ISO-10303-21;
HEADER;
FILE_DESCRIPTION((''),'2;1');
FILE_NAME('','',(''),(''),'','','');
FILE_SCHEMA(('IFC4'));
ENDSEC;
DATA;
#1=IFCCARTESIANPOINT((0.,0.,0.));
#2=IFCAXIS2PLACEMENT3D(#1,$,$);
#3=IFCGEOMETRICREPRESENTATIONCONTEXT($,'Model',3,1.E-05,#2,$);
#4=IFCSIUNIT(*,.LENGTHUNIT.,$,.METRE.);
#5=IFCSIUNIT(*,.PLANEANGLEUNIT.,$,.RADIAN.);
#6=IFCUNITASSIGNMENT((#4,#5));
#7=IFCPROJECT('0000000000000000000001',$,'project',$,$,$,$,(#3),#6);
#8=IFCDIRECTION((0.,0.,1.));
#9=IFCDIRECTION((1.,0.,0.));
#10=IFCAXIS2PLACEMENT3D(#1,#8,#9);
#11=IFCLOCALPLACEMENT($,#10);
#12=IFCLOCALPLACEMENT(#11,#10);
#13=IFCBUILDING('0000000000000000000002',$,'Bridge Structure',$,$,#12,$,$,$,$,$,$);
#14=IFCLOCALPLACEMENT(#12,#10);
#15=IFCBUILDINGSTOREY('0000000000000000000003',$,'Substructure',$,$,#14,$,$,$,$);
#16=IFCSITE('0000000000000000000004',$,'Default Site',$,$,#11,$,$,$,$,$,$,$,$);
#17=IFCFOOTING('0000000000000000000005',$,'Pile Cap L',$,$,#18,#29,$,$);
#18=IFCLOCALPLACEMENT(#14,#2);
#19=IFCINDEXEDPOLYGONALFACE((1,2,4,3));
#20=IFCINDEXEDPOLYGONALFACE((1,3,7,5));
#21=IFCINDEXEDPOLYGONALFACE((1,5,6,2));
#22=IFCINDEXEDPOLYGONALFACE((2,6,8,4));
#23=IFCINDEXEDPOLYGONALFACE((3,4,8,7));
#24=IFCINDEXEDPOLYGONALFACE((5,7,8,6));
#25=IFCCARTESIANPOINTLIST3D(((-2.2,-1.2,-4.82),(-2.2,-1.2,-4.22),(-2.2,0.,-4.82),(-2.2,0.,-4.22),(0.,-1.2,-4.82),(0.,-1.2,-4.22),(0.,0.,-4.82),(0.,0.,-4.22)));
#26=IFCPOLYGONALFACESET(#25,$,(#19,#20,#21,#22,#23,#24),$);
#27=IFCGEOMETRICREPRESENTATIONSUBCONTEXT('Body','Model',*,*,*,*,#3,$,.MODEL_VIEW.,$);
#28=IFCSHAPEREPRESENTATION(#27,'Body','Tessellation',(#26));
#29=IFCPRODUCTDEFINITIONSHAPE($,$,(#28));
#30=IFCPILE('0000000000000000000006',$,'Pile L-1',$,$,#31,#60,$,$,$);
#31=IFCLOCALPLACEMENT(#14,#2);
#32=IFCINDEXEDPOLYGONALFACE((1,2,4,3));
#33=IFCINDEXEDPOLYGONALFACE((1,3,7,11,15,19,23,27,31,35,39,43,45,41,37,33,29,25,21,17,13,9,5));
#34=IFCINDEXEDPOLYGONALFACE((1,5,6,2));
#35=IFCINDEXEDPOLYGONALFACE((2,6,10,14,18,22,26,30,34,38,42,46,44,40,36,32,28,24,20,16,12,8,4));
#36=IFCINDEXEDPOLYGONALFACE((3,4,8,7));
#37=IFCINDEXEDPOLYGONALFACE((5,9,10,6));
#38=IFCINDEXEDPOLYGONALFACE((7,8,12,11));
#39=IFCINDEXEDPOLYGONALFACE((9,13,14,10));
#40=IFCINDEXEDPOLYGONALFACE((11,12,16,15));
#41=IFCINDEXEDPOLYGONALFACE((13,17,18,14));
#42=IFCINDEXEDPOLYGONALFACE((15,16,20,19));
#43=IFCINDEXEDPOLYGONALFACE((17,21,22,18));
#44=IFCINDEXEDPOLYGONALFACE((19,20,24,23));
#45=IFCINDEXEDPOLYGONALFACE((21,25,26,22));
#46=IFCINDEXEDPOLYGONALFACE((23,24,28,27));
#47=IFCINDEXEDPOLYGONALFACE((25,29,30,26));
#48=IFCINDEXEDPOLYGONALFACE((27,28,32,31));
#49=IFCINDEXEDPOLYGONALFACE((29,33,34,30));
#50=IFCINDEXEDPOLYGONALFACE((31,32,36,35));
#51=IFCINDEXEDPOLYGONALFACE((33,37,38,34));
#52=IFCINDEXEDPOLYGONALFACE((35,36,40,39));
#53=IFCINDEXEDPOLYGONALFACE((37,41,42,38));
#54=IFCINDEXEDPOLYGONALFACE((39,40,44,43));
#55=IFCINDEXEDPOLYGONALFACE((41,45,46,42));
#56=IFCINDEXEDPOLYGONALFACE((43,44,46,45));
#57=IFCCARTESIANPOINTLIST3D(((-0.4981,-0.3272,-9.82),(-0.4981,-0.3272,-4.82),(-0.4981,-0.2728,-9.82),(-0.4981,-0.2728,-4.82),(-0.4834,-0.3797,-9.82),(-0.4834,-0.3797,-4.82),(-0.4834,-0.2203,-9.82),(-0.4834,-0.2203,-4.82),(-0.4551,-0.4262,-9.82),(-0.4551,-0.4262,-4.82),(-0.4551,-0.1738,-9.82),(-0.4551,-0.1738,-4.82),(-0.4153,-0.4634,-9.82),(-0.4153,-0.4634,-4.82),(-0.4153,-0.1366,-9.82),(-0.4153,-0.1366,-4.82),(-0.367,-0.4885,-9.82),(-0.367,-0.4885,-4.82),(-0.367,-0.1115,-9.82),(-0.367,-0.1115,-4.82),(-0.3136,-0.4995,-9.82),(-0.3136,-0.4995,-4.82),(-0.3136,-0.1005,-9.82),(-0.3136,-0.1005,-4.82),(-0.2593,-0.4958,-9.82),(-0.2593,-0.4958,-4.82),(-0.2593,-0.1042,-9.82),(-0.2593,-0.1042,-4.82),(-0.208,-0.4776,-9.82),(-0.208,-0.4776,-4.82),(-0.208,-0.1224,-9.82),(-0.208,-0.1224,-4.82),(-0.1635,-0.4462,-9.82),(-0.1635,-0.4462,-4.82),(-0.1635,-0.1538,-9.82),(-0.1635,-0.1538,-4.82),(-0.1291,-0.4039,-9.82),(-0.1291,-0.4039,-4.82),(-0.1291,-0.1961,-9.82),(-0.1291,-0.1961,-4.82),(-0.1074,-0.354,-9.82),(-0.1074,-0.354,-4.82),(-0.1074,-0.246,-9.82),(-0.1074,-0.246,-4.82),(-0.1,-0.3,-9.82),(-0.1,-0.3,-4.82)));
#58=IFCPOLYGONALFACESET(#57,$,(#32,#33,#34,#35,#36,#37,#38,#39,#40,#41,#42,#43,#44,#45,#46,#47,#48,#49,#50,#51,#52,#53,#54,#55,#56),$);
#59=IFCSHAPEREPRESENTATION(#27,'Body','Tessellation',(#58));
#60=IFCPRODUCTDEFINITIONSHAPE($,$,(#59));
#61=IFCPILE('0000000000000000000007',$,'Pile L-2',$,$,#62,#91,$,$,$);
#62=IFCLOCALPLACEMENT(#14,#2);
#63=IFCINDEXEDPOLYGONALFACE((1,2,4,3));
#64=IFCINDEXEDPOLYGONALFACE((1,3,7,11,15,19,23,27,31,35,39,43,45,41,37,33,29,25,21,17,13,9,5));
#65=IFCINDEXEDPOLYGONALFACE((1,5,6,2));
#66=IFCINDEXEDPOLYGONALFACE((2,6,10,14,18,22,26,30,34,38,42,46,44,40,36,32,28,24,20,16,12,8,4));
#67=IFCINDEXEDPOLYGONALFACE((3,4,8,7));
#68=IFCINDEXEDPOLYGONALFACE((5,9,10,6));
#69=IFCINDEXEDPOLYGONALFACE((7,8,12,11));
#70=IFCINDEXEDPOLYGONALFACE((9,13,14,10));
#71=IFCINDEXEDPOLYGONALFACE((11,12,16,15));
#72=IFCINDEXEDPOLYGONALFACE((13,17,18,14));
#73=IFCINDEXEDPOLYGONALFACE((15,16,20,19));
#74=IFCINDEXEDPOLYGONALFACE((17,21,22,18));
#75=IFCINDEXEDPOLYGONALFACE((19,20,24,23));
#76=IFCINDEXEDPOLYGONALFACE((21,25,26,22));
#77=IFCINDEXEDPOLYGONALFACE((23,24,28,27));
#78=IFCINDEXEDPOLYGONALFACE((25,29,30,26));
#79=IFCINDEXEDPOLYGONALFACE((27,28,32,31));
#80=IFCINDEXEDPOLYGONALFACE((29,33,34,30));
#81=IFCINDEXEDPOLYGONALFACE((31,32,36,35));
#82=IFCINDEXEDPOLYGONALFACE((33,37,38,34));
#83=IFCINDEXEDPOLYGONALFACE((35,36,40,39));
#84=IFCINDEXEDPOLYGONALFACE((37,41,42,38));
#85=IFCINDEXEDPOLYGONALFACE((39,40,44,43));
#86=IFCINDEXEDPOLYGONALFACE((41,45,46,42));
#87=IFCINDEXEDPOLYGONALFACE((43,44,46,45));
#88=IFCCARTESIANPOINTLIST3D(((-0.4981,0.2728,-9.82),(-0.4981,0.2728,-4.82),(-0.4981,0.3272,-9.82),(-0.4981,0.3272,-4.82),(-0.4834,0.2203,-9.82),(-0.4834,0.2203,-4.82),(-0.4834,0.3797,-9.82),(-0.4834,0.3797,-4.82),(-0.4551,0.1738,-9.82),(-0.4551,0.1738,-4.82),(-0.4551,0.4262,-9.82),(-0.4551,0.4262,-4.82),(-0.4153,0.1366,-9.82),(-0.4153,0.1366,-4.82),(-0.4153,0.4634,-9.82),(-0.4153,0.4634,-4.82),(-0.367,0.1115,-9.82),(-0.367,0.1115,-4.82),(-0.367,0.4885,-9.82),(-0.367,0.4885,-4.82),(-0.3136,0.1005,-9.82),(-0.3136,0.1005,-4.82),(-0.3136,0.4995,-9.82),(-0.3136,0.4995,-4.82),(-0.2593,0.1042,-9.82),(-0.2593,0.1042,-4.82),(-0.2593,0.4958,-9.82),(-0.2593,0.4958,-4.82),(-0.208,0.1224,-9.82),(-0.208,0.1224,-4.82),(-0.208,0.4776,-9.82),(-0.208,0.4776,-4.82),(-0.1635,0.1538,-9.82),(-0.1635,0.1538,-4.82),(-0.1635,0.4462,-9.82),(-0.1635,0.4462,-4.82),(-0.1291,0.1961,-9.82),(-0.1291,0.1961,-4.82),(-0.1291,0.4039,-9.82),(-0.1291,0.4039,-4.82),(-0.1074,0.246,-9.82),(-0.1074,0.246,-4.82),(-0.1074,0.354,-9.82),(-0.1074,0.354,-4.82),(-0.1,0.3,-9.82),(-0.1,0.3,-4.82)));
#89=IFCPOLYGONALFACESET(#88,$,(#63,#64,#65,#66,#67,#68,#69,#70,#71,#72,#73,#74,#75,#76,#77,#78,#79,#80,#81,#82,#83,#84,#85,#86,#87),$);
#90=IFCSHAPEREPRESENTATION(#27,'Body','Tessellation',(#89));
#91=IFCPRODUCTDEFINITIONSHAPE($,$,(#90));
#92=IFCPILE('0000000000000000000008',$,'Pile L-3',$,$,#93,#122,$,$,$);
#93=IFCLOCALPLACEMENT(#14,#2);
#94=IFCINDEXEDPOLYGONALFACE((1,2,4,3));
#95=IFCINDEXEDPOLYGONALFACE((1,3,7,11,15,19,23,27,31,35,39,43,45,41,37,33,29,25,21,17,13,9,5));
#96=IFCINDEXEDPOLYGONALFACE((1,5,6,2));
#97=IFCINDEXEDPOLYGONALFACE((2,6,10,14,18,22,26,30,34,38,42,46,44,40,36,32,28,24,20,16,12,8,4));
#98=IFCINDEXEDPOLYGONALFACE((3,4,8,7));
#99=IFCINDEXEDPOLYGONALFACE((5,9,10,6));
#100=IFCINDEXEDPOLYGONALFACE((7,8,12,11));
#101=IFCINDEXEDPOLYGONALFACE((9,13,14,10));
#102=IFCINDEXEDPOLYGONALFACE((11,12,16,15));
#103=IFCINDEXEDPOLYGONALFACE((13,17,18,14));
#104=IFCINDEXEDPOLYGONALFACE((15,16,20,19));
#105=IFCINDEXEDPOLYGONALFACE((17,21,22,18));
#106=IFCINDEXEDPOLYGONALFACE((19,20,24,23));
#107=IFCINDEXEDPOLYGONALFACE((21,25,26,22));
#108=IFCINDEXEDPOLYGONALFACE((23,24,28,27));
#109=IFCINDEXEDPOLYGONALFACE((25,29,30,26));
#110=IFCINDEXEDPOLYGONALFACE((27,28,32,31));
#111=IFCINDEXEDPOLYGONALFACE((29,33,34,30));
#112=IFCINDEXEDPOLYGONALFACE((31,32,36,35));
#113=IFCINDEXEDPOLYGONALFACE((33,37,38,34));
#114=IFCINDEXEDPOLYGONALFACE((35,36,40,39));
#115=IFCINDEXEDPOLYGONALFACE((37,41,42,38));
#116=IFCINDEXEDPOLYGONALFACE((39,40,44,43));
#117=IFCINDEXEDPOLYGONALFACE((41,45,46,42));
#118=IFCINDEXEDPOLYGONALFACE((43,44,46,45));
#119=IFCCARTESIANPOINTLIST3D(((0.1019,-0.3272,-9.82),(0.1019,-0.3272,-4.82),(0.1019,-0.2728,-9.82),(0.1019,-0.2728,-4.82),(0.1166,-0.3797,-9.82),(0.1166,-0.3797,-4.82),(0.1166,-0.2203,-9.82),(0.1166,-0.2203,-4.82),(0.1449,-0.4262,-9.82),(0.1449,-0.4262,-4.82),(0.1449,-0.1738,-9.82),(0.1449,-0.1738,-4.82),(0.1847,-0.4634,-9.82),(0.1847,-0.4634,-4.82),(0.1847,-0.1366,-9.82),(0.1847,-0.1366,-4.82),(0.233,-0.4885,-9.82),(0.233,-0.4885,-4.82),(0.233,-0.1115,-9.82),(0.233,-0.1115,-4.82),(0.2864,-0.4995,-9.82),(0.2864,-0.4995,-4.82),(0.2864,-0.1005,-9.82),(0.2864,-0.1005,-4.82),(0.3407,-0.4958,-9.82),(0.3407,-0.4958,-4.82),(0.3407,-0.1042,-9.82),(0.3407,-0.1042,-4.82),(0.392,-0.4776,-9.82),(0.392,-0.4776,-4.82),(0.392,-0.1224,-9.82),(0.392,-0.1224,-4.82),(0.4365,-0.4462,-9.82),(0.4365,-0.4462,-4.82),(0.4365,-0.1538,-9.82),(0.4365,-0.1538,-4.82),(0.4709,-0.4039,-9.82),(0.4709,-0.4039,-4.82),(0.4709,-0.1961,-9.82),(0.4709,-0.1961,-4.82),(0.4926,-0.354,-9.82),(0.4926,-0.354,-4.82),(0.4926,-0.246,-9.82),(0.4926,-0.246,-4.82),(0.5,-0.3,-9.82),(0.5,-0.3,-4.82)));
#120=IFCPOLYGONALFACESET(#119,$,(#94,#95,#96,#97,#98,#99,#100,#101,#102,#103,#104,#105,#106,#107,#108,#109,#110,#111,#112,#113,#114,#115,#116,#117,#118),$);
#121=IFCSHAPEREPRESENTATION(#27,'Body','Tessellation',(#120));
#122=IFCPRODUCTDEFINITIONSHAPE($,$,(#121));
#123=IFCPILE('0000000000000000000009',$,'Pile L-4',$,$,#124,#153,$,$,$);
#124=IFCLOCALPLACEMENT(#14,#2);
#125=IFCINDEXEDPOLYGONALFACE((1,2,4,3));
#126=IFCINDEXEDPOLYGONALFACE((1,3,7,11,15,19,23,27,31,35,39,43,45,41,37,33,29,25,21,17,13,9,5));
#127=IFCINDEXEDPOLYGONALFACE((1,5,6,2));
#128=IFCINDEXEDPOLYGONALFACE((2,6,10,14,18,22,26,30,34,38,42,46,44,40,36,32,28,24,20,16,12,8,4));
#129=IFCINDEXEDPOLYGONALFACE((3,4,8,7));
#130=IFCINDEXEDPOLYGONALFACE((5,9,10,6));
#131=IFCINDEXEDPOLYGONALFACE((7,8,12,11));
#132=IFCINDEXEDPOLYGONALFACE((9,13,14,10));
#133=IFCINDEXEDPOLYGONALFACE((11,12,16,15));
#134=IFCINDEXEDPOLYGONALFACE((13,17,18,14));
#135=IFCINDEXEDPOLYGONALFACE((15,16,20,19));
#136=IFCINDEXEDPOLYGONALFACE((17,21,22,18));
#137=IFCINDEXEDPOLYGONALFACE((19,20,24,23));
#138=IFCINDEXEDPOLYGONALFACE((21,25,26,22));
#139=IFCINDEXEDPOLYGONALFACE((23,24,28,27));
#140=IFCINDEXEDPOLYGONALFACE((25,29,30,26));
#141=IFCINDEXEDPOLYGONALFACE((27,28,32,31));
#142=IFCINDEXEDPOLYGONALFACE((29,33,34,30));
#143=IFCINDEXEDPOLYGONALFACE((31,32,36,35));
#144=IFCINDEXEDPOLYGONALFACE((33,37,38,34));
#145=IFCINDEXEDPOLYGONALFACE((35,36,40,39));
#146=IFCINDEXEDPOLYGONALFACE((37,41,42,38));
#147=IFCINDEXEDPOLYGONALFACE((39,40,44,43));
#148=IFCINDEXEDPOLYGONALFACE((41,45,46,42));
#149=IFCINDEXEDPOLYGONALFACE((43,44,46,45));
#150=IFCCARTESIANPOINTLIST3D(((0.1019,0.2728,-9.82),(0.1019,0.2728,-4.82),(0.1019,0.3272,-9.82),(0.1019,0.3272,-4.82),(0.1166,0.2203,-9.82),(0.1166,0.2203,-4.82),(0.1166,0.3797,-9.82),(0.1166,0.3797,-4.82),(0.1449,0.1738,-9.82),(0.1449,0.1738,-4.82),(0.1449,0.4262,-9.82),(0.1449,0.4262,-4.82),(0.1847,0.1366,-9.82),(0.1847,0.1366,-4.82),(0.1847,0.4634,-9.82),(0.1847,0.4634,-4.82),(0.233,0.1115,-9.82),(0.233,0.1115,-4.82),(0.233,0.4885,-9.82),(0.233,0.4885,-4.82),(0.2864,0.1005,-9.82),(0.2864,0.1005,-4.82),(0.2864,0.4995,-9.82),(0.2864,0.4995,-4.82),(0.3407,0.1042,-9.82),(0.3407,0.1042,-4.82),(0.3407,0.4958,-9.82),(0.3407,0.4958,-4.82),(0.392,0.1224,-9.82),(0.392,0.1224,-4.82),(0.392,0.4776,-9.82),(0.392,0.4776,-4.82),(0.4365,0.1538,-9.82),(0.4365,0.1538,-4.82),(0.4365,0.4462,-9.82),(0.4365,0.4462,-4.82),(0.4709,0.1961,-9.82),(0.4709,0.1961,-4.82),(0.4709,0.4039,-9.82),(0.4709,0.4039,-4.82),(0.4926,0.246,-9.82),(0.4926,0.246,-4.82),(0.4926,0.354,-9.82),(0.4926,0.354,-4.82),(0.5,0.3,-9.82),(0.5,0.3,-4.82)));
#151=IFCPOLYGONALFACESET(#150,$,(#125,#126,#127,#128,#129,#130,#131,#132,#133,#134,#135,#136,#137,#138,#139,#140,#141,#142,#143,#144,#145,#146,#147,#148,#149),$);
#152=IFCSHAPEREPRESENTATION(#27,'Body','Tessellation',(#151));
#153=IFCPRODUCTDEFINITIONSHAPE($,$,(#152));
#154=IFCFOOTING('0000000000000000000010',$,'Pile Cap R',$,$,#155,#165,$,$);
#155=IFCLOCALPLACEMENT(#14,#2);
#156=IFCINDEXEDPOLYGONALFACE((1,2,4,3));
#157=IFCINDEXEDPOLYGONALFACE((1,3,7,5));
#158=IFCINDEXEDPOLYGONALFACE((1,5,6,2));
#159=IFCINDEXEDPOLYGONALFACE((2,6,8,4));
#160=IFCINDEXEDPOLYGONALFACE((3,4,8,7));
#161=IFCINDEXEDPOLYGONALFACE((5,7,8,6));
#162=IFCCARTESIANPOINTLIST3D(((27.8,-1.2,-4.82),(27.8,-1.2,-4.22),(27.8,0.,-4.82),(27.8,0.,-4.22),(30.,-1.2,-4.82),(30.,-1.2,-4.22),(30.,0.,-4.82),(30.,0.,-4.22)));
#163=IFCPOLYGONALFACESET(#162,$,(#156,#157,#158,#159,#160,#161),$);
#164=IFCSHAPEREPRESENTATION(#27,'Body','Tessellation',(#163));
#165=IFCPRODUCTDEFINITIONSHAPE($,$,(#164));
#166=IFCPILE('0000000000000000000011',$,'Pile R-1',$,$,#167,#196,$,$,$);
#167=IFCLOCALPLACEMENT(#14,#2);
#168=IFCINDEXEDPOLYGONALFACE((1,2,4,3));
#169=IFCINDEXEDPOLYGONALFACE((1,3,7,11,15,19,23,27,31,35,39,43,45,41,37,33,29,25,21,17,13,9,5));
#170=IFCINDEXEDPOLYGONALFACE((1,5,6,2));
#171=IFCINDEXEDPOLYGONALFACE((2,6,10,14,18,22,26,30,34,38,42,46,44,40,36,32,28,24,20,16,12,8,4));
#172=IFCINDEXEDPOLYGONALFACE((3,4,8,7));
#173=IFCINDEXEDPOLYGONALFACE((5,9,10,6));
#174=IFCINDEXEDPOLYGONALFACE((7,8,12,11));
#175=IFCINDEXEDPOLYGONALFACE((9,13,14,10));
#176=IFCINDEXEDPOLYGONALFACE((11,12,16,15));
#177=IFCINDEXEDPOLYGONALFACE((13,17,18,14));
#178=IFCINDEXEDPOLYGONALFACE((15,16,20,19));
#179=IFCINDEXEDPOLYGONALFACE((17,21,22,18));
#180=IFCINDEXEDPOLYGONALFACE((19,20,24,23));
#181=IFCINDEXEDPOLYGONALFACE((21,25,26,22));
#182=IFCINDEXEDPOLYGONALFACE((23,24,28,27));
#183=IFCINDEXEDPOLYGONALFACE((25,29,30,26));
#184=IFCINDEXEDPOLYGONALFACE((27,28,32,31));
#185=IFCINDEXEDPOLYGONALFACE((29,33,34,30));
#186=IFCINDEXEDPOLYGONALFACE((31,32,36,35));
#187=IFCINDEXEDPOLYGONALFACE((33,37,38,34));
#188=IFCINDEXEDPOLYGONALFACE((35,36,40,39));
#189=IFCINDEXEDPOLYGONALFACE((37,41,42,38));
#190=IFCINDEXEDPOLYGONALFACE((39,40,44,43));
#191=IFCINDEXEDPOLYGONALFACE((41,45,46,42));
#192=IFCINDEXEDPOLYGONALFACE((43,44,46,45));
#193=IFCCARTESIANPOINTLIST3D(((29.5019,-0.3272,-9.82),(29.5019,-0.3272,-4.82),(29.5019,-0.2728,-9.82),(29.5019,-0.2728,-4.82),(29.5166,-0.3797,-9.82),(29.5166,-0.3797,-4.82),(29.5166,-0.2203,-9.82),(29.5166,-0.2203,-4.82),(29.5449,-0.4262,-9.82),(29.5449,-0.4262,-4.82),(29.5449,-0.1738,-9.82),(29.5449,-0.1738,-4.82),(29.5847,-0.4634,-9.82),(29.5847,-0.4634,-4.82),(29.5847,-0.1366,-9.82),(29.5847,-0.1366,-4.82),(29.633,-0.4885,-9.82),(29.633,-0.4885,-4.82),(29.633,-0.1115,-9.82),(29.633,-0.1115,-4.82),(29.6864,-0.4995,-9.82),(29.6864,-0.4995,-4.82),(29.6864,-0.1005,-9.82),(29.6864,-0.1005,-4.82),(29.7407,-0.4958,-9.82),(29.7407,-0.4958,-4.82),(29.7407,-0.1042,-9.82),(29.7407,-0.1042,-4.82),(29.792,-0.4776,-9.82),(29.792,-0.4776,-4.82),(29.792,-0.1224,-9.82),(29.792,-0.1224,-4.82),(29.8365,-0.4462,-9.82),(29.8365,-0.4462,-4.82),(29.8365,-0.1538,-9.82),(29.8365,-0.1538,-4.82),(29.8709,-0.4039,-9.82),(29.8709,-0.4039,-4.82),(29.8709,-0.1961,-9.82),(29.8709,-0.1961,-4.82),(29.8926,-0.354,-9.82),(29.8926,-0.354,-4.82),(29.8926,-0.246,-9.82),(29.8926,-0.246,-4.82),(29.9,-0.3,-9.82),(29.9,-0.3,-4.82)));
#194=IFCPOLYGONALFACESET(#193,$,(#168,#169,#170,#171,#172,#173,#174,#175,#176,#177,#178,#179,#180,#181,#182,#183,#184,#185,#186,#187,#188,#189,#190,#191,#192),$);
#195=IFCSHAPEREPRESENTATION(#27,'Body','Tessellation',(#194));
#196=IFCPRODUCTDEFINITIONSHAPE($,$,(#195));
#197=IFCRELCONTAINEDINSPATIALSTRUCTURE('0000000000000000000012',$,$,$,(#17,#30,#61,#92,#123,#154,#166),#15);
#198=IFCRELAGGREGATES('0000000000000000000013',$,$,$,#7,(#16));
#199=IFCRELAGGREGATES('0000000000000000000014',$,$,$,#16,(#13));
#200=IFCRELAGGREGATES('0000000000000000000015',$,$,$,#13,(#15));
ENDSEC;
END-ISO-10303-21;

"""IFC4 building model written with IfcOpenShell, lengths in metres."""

from ifc_helpers import new_model, si_unit, frame, origin, origin_with_axes, origin_2d_with_axis, place, context, subcontext, project, spatial, rectangle, circle, extrude, element, save


model = new_model("IFC4")

# Units and contexts
model_context = context("Model", 3, precision=1e-05, world=origin())
body_context = subcontext(model_context, "Body", "Model", "MODEL_VIEW")
ifc_project = project(units=[si_unit("LENGTHUNIT", "METRE"), si_unit("PLANEANGLEUNIT", "RADIAN")], contexts=[model_context])

# Site, building, storey
site_placement = place(None, origin_with_axes())
site = spatial("IfcSite", under=ifc_project, at=site_placement, Name="Default Site")
building_placement = place(site_placement, origin_with_axes())
building = spatial("IfcBuilding", under=site, at=building_placement, Name="Bridge Structure")
storey_placement = place(building_placement, origin_with_axes())
storey = spatial("IfcBuildingStorey", under=building, at=storey_placement, Name="Substructure")

# Footing
footing_1_placement = place(storey_placement, frame((-1.1, -0.6, -4.82), z_axis=(0.0, 0.0, 1.0), x_axis=(1.0, 0.0, 0.0)))
element("IfcFooting", 1, at=footing_1_placement, inside=storey, Name="Pile Cap L", context=body_context, shape_type="SweptSolid", body=[
    extrude(rectangle(XDim=2.2, YDim=1.2, at=origin_2d_with_axis()), origin_with_axes(), (0.0, 0.0, 1.0), 0.6),
])

# Piles
for number, where, z_axis, x_axis, name in (
    (2, (-0.3, -0.3, -9.82), (0.0, 0.0, 1.0), (1.0, 0.0, 0.0), "Pile L-1"),
    (3, (-0.3, 0.3, -9.82), (0.0, 0.0, 1.0), (1.0, 0.0, 0.0), "Pile L-2"),
    (4, (0.3, -0.3, -9.82), (0.0, 0.0, 1.0), (1.0, 0.0, 0.0), "Pile L-3"),
    (5, (0.3, 0.3, -9.82), (0.0, 0.0, 1.0), (1.0, 0.0, 0.0), "Pile L-4"),
):
    element("IfcPile", number, at=place(storey_placement, frame(where, z_axis=z_axis, x_axis=x_axis)), inside=storey, Name=name, context=body_context, shape_type="SweptSolid", body=[
        extrude(circle(Radius=0.2, at=origin_2d_with_axis()), origin_with_axes(), (0.0, 0.0, 1.0), 5.0),
    ])

# Footing
footing_2_placement = place(storey_placement, frame((28.9, -0.6, -4.82), z_axis=(0.0, 0.0, 1.0), x_axis=(1.0, 0.0, 0.0)))
element("IfcFooting", 6, at=footing_2_placement, inside=storey, Name="Pile Cap R", context=body_context, shape_type="SweptSolid", body=[
    extrude(rectangle(XDim=2.2, YDim=1.2, at=origin_2d_with_axis()), origin_with_axes(), (0.0, 0.0, 1.0), 0.6),
])

# Pile
for number, where, z_axis, x_axis, name in (
    (7, (29.7, -0.3, -9.82), (0.0, 0.0, 1.0), (1.0, 0.0, 0.0), "Pile R-1"),
):
    element("IfcPile", number, at=place(storey_placement, frame(where, z_axis=z_axis, x_axis=x_axis)), inside=storey, Name=name, context=body_context, shape_type="SweptSolid", body=[
        extrude(circle(Radius=0.2, at=origin_2d_with_axis()), origin_with_axes(), (0.0, 0.0, 1.0), 5.0),
    ])

save(model, "model.ifc")
